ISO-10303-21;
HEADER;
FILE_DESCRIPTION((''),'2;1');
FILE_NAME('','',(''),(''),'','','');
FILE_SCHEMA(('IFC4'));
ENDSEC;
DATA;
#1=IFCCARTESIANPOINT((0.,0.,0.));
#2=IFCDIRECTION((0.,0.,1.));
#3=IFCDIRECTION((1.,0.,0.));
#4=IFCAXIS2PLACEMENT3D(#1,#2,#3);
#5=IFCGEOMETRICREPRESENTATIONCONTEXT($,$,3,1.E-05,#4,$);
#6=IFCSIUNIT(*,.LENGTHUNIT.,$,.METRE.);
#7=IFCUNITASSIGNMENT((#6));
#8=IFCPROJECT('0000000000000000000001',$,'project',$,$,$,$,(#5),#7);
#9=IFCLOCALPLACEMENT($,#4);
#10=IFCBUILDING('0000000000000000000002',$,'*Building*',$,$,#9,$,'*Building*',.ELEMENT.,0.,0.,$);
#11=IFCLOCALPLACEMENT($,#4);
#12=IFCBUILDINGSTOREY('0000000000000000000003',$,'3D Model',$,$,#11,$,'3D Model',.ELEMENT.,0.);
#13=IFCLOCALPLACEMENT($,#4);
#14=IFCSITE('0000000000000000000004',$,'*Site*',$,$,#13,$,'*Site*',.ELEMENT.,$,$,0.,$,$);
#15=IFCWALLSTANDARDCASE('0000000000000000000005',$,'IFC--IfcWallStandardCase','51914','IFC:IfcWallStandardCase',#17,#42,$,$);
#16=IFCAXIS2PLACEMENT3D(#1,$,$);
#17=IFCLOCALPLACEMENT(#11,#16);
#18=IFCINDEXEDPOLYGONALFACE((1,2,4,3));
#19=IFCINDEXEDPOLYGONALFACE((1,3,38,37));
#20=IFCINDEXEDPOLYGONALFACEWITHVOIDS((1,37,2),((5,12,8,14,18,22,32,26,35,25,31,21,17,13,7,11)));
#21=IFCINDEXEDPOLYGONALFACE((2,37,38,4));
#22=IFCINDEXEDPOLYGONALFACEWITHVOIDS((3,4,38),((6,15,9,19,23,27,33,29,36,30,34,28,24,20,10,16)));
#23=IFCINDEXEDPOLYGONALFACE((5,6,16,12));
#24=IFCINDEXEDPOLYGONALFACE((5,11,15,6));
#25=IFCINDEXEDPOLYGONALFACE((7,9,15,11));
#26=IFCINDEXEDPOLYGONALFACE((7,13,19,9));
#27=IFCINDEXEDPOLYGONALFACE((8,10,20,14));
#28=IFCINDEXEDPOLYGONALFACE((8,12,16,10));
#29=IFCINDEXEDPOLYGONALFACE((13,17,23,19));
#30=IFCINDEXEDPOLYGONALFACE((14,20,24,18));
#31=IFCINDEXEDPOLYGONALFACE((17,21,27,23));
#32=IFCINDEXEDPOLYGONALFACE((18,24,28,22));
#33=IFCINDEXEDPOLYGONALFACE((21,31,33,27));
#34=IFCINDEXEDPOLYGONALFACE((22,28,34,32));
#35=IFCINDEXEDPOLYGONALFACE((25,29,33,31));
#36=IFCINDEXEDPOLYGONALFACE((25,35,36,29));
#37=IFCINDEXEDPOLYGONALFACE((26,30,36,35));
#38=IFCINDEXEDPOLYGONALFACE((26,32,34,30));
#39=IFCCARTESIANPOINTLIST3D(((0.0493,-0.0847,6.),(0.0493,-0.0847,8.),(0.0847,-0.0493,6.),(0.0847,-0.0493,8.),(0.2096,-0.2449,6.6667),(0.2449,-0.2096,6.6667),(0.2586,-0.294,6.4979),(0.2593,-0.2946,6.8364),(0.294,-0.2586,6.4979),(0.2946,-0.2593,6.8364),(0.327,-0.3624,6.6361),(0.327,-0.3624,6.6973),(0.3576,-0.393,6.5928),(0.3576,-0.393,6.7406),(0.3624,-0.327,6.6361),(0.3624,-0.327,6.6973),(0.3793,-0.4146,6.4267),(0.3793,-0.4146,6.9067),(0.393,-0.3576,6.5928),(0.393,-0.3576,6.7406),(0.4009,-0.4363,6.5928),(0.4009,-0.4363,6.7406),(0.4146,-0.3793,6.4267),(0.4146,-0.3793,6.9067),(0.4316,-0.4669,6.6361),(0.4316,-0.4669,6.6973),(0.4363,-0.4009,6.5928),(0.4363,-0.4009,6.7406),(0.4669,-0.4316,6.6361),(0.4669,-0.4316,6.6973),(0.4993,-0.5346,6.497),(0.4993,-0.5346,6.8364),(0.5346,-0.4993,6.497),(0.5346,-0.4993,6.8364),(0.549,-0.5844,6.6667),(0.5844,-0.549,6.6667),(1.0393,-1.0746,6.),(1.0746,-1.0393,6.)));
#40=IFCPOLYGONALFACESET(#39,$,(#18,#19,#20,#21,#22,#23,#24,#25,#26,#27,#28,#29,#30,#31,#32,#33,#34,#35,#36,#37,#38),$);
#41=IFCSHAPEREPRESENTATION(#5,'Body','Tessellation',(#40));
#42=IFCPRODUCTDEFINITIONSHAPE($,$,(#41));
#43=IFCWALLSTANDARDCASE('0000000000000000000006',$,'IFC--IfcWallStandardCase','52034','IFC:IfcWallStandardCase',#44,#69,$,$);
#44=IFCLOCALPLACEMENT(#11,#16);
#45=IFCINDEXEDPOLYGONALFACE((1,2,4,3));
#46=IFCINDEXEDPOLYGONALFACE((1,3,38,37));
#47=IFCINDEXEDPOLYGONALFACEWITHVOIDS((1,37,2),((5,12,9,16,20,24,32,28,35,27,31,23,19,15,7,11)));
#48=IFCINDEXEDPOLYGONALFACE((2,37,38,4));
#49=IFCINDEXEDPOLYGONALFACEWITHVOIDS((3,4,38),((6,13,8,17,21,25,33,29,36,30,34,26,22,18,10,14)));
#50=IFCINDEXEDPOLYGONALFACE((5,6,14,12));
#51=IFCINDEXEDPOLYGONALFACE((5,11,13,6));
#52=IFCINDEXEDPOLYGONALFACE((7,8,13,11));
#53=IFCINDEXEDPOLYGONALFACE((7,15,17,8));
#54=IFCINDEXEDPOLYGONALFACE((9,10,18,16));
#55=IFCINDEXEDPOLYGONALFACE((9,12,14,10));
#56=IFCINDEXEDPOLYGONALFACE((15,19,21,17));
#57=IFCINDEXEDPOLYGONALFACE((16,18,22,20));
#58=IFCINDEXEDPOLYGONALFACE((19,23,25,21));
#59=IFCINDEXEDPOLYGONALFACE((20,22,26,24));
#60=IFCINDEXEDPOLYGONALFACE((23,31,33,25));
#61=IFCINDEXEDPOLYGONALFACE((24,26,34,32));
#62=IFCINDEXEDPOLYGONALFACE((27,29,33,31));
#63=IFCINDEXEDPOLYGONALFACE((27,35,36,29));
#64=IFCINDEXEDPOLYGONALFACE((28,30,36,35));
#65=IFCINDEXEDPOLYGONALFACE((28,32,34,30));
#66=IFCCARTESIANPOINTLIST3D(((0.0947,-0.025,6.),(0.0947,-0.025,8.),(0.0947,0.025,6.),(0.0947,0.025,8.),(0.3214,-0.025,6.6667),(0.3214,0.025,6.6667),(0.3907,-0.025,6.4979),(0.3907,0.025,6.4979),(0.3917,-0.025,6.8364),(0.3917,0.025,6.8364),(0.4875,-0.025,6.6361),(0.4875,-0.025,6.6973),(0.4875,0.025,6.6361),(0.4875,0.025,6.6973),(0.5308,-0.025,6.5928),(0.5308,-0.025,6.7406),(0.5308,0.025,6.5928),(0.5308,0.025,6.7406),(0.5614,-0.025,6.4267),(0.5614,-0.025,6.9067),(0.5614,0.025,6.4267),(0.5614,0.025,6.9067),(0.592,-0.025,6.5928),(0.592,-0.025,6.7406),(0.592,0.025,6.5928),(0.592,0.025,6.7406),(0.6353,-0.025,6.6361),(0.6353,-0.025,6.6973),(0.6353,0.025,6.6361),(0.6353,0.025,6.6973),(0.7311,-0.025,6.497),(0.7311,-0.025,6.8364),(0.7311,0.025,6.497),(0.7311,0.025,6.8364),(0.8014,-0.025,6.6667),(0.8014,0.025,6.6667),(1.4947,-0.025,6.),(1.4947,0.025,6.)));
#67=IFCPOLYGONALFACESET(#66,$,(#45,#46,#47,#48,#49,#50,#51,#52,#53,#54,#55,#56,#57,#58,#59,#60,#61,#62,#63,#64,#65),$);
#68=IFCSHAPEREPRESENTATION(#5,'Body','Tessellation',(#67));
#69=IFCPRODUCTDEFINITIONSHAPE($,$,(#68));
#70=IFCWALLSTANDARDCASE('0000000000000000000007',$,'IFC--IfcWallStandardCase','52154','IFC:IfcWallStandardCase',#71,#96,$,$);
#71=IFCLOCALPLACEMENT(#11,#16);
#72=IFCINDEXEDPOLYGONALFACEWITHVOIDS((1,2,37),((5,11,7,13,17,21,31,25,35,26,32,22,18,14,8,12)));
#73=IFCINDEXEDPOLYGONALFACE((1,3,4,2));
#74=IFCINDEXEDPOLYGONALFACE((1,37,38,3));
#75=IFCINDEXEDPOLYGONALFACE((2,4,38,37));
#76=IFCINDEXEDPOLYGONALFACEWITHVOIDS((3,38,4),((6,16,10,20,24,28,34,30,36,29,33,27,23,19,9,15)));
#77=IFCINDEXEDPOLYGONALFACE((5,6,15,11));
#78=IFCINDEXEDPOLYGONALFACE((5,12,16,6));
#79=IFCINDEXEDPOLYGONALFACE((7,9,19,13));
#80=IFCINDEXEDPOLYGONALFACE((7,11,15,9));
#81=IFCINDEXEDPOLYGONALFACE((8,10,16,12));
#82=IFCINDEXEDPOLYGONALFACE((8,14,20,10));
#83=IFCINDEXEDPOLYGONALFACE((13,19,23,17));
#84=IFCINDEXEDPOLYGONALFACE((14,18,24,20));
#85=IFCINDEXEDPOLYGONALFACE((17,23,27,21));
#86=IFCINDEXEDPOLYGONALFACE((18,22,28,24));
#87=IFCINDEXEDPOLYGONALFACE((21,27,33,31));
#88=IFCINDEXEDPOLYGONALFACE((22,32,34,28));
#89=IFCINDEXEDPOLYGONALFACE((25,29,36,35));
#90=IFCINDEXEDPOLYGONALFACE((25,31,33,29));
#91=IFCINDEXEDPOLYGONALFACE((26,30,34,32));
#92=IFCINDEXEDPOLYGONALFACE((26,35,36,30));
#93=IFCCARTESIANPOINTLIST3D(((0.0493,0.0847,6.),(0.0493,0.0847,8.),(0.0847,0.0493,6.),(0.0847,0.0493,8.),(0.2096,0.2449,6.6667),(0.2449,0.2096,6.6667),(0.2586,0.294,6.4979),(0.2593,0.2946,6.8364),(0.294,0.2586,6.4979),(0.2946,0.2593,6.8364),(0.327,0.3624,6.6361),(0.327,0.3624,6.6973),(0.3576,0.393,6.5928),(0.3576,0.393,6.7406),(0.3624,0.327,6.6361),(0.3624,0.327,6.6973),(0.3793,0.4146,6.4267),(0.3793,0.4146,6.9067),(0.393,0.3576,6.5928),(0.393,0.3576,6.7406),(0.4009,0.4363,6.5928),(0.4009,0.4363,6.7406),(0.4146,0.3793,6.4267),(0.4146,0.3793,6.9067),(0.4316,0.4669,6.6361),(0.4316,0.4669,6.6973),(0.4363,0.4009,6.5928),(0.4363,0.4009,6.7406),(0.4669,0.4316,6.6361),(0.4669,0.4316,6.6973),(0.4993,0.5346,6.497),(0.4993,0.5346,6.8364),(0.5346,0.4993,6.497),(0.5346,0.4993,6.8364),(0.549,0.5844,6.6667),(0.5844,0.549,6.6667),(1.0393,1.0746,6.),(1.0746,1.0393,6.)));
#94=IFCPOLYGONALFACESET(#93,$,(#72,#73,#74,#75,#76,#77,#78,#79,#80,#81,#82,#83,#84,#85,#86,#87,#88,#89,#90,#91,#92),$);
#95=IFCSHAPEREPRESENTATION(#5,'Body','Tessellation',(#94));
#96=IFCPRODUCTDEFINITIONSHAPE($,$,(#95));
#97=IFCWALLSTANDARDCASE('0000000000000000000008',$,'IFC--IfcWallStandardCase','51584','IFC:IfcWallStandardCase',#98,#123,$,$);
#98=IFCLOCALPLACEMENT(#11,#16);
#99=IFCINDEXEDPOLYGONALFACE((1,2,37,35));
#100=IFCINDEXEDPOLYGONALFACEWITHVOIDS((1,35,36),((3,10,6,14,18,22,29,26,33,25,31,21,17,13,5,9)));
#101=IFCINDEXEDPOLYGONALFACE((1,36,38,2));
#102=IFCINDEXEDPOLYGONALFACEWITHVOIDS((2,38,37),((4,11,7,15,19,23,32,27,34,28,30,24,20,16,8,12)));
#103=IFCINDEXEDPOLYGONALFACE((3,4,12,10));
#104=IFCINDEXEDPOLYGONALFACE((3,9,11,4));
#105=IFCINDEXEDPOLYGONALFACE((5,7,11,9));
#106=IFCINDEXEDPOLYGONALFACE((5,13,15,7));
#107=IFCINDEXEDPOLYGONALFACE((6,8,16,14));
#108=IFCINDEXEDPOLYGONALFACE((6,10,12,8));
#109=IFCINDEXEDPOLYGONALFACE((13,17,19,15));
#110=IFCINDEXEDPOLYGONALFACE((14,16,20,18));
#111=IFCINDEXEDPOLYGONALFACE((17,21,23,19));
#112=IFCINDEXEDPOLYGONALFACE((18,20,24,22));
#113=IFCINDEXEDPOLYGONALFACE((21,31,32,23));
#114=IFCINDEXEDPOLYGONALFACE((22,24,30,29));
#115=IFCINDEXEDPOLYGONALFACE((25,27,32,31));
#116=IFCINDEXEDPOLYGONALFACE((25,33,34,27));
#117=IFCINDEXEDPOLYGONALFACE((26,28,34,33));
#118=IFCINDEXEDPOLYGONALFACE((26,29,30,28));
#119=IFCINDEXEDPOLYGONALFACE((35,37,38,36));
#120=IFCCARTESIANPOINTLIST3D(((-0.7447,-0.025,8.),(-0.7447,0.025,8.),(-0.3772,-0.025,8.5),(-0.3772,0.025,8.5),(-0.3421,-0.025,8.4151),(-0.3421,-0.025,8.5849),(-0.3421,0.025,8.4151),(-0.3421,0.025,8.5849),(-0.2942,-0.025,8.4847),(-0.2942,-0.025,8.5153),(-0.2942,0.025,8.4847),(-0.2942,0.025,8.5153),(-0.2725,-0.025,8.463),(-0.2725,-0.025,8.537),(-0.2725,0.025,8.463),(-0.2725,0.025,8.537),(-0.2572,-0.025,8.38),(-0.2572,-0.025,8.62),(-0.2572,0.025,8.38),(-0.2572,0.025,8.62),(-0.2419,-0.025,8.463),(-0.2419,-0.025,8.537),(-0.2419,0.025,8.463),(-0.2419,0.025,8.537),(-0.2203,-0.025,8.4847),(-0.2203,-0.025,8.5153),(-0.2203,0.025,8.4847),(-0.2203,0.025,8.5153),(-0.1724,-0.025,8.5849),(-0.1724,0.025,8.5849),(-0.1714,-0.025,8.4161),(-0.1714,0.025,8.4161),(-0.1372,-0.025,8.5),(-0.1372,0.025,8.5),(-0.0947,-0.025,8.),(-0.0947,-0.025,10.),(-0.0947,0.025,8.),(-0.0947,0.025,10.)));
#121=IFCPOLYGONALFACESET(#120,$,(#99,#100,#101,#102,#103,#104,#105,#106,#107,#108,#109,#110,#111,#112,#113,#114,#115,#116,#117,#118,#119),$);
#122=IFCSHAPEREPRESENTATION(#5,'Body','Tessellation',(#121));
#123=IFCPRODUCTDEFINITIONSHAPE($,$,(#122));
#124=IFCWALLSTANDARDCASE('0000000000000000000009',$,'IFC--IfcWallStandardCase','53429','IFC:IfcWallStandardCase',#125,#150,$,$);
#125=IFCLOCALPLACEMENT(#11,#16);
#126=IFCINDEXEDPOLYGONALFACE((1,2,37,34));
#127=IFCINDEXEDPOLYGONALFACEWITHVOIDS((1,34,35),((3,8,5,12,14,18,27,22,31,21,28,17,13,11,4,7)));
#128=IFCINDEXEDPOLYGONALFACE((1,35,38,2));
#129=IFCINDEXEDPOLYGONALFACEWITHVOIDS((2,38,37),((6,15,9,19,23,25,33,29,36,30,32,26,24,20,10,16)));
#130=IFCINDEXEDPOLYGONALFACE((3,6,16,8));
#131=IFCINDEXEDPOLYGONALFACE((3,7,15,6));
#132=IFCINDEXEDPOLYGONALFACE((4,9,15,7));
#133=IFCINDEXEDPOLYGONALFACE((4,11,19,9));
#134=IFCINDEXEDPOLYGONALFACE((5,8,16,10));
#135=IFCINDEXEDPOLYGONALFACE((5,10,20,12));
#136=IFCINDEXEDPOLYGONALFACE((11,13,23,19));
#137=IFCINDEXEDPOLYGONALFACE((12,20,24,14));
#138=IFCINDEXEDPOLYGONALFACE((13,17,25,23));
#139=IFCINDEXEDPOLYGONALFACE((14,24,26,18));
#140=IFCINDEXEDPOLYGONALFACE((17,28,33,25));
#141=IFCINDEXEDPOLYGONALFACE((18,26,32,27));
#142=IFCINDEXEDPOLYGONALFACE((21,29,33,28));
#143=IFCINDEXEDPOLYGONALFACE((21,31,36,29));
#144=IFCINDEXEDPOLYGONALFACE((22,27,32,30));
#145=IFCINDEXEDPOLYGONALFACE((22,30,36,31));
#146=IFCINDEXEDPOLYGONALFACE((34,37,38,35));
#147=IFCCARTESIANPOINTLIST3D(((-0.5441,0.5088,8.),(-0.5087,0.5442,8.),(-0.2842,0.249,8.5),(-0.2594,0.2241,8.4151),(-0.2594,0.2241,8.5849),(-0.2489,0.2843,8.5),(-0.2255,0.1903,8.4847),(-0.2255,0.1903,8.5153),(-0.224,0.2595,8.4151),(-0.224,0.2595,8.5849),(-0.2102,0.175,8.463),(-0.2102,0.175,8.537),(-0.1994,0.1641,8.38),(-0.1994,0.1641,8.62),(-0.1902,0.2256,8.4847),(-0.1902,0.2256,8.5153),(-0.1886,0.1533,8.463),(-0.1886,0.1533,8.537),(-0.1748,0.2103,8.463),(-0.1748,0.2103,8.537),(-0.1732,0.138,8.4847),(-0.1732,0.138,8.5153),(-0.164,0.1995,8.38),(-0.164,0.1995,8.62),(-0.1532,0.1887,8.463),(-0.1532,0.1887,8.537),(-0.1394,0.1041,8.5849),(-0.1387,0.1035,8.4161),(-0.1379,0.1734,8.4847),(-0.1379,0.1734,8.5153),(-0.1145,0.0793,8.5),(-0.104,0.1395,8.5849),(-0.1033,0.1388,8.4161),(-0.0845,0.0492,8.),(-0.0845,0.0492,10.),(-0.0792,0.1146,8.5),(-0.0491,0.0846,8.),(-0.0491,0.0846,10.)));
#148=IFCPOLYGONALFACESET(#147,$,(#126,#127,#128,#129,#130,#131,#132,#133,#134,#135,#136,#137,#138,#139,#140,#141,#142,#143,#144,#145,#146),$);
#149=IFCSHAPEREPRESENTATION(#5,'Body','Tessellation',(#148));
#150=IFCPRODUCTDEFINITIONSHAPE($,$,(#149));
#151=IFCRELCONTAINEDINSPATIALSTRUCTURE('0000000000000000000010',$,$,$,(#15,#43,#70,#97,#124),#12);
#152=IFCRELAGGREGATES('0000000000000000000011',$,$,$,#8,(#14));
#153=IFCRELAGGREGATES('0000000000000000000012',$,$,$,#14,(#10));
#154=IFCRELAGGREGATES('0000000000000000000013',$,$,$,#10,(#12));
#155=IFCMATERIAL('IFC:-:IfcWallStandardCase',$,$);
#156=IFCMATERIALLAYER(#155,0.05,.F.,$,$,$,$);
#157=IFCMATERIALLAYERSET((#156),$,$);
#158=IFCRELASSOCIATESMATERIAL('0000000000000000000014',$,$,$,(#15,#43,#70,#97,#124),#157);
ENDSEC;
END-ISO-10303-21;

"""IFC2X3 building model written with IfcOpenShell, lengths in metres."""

from ifc_helpers import new_model, si_unit, frame, frame_2d, origin_with_axes, place, context, project, spatial, polyline, rectangle, outline, extrude, clip, halfspace, material, layer, layer_set, layer_usage, element, save


model = new_model("IFC2X3")

# Units and contexts
context_of_model = context(None, 3, precision=1e-05, world=origin_with_axes())
ifc_project = project(units=[si_unit("LENGTHUNIT", "METRE")], contexts=[context_of_model])

# Site, building, storey
site_placement = place(None, origin_with_axes())
site = spatial("IfcSite", under=ifc_project, at=site_placement, Name="*Site*", LongName="*Site*", CompositionType="ELEMENT", RefElevation=0.0)
building_placement = place(None, origin_with_axes())
building = spatial("IfcBuilding", under=site, at=building_placement, Name="*Building*", LongName="*Building*", CompositionType="ELEMENT", ElevationOfRefHeight=0.0, ElevationOfTerrain=0.0)
storey_placement = place(None, origin_with_axes())
storey = spatial("IfcBuildingStorey", under=building, at=storey_placement, Name="3D Model", LongName="3D Model", CompositionType="ELEMENT", Elevation=0.0)

# Walls, openings
ifc_material = material(Name="IFC:-:IfcWallStandardCase")
ifc_layer = layer(ifc_material, 0.05, ventilated=False)
ifc_layer_set = layer_set([ifc_layer])
ifc_layer_usage = layer_usage(ifc_layer_set, "AXIS2", "POSITIVE", 0.0)
wall_1_placement = place(None, frame((0.067, -0.067, 6.0), z_axis=(0.0, 0.0, 1.0), x_axis=(0.707109, -0.707105, 0.0)))
wall_1 = element("IfcWallStandardCase", 1, at=wall_1_placement, inside=storey, material=ifc_layer_usage, Name="IFC--IfcWallStandardCase", Description="51914", ObjectType="IFC:IfcWallStandardCase", context=context_of_model, shape_type="Clipping", body=[
    clip(extrude(rectangle(XDim=1.4, YDim=0.05, at=frame_2d((0.7, 0.0), x_axis=(1.0, 0.0))), origin_with_axes(), (0.0, 0.0, 1.0), 2.0), halfspace(frame((0.9396, 0.0, 0.6577), z_axis=(-0.819232, 0.000002, -0.573462), x_axis=(-0.000003, -1.0, 0.0)), True)),
])
opening_1_placement = place(wall_1_placement, frame((0.2267, 0.025, 0.4267), z_axis=(0.0, 0.0, 1.0), x_axis=(1.0, 0.0, 0.0)))
element("IfcOpeningElement", 2, at=opening_1_placement, cuts=wall_1, context=context_of_model, shape_type="SweptSolid", body=[
    extrude(outline(polyline([(-0.3139, 0.2094), (-0.4097, 0.0703), (-0.2706, 0.1661), (-0.24, 0.0), (-0.2094, 0.1661), (-0.0693, 0.0713), (-0.1661, 0.2094), (0.0, 0.24), (-0.1661, 0.2706), (-0.0703, 0.4097), (-0.2094, 0.3139), (-0.24, 0.48), (-0.2706, 0.3139), (-0.4097, 0.4097), (-0.3139, 0.2706), (-0.48, 0.24), (-0.3139, 0.2094)])), frame((0.0, 0.0, 0.0), z_axis=(0.0, 1.0, 0.0), x_axis=(-1.0, 0.0, 0.0)), (0.0, 0.0, -1.0), 0.15),
])
wall_2_placement = place(None, frame((0.0947, 0.0, 6.0), z_axis=(0.0, 0.0, 1.0), x_axis=(1.0, 0.000003, 0.0)))
wall_2 = element("IfcWallStandardCase", 3, at=wall_2_placement, inside=storey, material=ifc_layer_usage, Name="IFC--IfcWallStandardCase", Description="52034", ObjectType="IFC:IfcWallStandardCase", context=context_of_model, shape_type="Clipping", body=[
    clip(extrude(rectangle(XDim=1.4, YDim=0.05, at=frame_2d((0.7, 0.0), x_axis=(1.0, 0.0))), origin_with_axes(), (0.0, 0.0, 1.0), 2.0), halfspace(frame((0.9396, 0.0, 0.6577), z_axis=(-0.819232, 0.000002, -0.573462), x_axis=(-0.000003, -1.0, 0.0)), True)),
])
opening_2_placement = place(wall_2_placement, frame((0.2267, 0.025, 0.4267), z_axis=(0.0, 0.0, 1.0), x_axis=(1.0, 0.0, 0.0)))
element("IfcOpeningElement", 4, at=opening_2_placement, cuts=wall_2, context=context_of_model, shape_type="SweptSolid", body=[
    extrude(outline(polyline([(-0.3139, 0.2094), (-0.4097, 0.0703), (-0.2706, 0.1661), (-0.24, 0.0), (-0.2094, 0.1661), (-0.0693, 0.0713), (-0.1661, 0.2094), (0.0, 0.24), (-0.1661, 0.2706), (-0.0703, 0.4097), (-0.2094, 0.3139), (-0.24, 0.48), (-0.2706, 0.3139), (-0.4097, 0.4097), (-0.3139, 0.2706), (-0.48, 0.24), (-0.3139, 0.2094)])), frame((0.0, 0.0, 0.0), z_axis=(0.0, 1.0, 0.0), x_axis=(-1.0, 0.0, 0.0)), (0.0, 0.0, -1.0), 0.15),
])
wall_3_placement = place(None, frame((0.067, 0.067, 6.0), z_axis=(0.0, 0.0, 1.0), x_axis=(0.707105, 0.707109, 0.0)))
wall_3 = element("IfcWallStandardCase", 5, at=wall_3_placement, inside=storey, material=ifc_layer_usage, Name="IFC--IfcWallStandardCase", Description="52154", ObjectType="IFC:IfcWallStandardCase", context=context_of_model, shape_type="Clipping", body=[
    clip(extrude(rectangle(XDim=1.4, YDim=0.05, at=frame_2d((0.7, 0.0), x_axis=(1.0, 0.0))), origin_with_axes(), (0.0, 0.0, 1.0), 2.0), halfspace(frame((0.9396, 0.0, 0.6577), z_axis=(-0.819232, 0.000002, -0.573462), x_axis=(-0.000003, -1.0, 0.0)), True)),
])
opening_3_placement = place(wall_3_placement, frame((0.2267, 0.025, 0.4267), z_axis=(0.0, 0.0, 1.0), x_axis=(1.0, 0.0, 0.0)))
element("IfcOpeningElement", 6, at=opening_3_placement, cuts=wall_3, context=context_of_model, shape_type="SweptSolid", body=[
    extrude(outline(polyline([(-0.3139, 0.2094), (-0.4097, 0.0703), (-0.2706, 0.1661), (-0.24, 0.0), (-0.2094, 0.1661), (-0.0693, 0.0713), (-0.1661, 0.2094), (0.0, 0.24), (-0.1661, 0.2706), (-0.0703, 0.4097), (-0.2094, 0.3139), (-0.24, 0.48), (-0.2706, 0.3139), (-0.4097, 0.4097), (-0.3139, 0.2706), (-0.48, 0.24), (-0.3139, 0.2094)])), frame((0.0, 0.0, 0.0), z_axis=(0.0, 1.0, 0.0), x_axis=(-1.0, 0.0, 0.0)), (0.0, 0.0, -1.0), 0.15),
])
wall_4_placement = place(None, frame((-0.0947, 0.0, 8.0), z_axis=(0.0, 0.0, 1.0), x_axis=(-1.0, -0.000003, 0.0)))
wall_4 = element("IfcWallStandardCase", 7, at=wall_4_placement, inside=storey, material=ifc_layer_usage, Name="IFC--IfcWallStandardCase", Description="51584", ObjectType="IFC:IfcWallStandardCase", context=context_of_model, shape_type="Clipping", body=[
    clip(extrude(rectangle(XDim=0.65, YDim=0.05, at=frame_2d((0.325, 0.0), x_axis=(1.0, 0.0))), origin_with_axes(), (0.0, 0.0, 1.0), 2.0), halfspace(frame((0.5879, 0.0, 0.1911), z_axis=(-0.951034, 0.000003, -0.309086), x_axis=(-0.000003, -1.0, 0.0)), True)),
])
opening_4_placement = place(wall_4_placement, frame((0.0425, 0.025, 0.38), z_axis=(0.0, 0.0, 1.0), x_axis=(1.0, 0.0, 0.0)))
element("IfcOpeningElement", 8, at=opening_4_placement, cuts=wall_4, context=context_of_model, shape_type="SweptSolid", body=[
    extrude(outline(polyline([(-0.157, 0.1047), (-0.2049, 0.0351), (-0.1353, 0.083), (-0.12, 0.0), (-0.1047, 0.083), (-0.0342, 0.0361), (-0.083, 0.1047), (0.0, 0.12), (-0.083, 0.1353), (-0.0351, 0.2049), (-0.1047, 0.157), (-0.12, 0.24), (-0.1353, 0.157), (-0.2049, 0.2049), (-0.157, 0.1353), (-0.24, 0.12), (-0.157, 0.1047)])), frame((0.0, 0.0, 0.0), z_axis=(0.0, 1.0, 0.0), x_axis=(-1.0, 0.0, 0.0)), (0.0, 0.0, -1.0), 0.15),
])
wall_5_placement = place(None, frame((-0.0668, 0.0669, 8.0), z_axis=(0.0, 0.0, 1.0), x_axis=(-0.707109, 0.707105, 0.0)))
wall_5 = element("IfcWallStandardCase", 9, at=wall_5_placement, inside=storey, material=ifc_layer_usage, Name="IFC--IfcWallStandardCase", Description="53429", ObjectType="IFC:IfcWallStandardCase", context=context_of_model, shape_type="Clipping", body=[
    clip(extrude(rectangle(XDim=0.65, YDim=0.05, at=frame_2d((0.325, 0.0), x_axis=(1.0, 0.0))), origin_with_axes(), (0.0, 0.0, 1.0), 2.0), halfspace(frame((0.5879, 0.0, 0.1911), z_axis=(-0.951034, 0.000003, -0.309086), x_axis=(-0.000003, -1.0, 0.0)), True)),
])
opening_5_placement = place(wall_5_placement, frame((0.0425, 0.025, 0.38), z_axis=(0.0, 0.0, 1.0), x_axis=(1.0, 0.0, 0.0)))
element("IfcOpeningElement", 10, at=opening_5_placement, cuts=wall_5, context=context_of_model, shape_type="SweptSolid", body=[
    extrude(outline(polyline([(-0.157, 0.1047), (-0.2049, 0.0351), (-0.1353, 0.083), (-0.12, 0.0), (-0.1047, 0.083), (-0.0342, 0.0361), (-0.083, 0.1047), (0.0, 0.12), (-0.083, 0.1353), (-0.0351, 0.2049), (-0.1047, 0.157), (-0.12, 0.24), (-0.1353, 0.157), (-0.2049, 0.2049), (-0.157, 0.1353), (-0.24, 0.12), (-0.157, 0.1047)])), frame((0.0, 0.0, 0.0), z_axis=(0.0, 1.0, 0.0), x_axis=(-1.0, 0.0, 0.0)), (0.0, 0.0, -1.0), 0.15),
])

save(model, "model.ifc")
